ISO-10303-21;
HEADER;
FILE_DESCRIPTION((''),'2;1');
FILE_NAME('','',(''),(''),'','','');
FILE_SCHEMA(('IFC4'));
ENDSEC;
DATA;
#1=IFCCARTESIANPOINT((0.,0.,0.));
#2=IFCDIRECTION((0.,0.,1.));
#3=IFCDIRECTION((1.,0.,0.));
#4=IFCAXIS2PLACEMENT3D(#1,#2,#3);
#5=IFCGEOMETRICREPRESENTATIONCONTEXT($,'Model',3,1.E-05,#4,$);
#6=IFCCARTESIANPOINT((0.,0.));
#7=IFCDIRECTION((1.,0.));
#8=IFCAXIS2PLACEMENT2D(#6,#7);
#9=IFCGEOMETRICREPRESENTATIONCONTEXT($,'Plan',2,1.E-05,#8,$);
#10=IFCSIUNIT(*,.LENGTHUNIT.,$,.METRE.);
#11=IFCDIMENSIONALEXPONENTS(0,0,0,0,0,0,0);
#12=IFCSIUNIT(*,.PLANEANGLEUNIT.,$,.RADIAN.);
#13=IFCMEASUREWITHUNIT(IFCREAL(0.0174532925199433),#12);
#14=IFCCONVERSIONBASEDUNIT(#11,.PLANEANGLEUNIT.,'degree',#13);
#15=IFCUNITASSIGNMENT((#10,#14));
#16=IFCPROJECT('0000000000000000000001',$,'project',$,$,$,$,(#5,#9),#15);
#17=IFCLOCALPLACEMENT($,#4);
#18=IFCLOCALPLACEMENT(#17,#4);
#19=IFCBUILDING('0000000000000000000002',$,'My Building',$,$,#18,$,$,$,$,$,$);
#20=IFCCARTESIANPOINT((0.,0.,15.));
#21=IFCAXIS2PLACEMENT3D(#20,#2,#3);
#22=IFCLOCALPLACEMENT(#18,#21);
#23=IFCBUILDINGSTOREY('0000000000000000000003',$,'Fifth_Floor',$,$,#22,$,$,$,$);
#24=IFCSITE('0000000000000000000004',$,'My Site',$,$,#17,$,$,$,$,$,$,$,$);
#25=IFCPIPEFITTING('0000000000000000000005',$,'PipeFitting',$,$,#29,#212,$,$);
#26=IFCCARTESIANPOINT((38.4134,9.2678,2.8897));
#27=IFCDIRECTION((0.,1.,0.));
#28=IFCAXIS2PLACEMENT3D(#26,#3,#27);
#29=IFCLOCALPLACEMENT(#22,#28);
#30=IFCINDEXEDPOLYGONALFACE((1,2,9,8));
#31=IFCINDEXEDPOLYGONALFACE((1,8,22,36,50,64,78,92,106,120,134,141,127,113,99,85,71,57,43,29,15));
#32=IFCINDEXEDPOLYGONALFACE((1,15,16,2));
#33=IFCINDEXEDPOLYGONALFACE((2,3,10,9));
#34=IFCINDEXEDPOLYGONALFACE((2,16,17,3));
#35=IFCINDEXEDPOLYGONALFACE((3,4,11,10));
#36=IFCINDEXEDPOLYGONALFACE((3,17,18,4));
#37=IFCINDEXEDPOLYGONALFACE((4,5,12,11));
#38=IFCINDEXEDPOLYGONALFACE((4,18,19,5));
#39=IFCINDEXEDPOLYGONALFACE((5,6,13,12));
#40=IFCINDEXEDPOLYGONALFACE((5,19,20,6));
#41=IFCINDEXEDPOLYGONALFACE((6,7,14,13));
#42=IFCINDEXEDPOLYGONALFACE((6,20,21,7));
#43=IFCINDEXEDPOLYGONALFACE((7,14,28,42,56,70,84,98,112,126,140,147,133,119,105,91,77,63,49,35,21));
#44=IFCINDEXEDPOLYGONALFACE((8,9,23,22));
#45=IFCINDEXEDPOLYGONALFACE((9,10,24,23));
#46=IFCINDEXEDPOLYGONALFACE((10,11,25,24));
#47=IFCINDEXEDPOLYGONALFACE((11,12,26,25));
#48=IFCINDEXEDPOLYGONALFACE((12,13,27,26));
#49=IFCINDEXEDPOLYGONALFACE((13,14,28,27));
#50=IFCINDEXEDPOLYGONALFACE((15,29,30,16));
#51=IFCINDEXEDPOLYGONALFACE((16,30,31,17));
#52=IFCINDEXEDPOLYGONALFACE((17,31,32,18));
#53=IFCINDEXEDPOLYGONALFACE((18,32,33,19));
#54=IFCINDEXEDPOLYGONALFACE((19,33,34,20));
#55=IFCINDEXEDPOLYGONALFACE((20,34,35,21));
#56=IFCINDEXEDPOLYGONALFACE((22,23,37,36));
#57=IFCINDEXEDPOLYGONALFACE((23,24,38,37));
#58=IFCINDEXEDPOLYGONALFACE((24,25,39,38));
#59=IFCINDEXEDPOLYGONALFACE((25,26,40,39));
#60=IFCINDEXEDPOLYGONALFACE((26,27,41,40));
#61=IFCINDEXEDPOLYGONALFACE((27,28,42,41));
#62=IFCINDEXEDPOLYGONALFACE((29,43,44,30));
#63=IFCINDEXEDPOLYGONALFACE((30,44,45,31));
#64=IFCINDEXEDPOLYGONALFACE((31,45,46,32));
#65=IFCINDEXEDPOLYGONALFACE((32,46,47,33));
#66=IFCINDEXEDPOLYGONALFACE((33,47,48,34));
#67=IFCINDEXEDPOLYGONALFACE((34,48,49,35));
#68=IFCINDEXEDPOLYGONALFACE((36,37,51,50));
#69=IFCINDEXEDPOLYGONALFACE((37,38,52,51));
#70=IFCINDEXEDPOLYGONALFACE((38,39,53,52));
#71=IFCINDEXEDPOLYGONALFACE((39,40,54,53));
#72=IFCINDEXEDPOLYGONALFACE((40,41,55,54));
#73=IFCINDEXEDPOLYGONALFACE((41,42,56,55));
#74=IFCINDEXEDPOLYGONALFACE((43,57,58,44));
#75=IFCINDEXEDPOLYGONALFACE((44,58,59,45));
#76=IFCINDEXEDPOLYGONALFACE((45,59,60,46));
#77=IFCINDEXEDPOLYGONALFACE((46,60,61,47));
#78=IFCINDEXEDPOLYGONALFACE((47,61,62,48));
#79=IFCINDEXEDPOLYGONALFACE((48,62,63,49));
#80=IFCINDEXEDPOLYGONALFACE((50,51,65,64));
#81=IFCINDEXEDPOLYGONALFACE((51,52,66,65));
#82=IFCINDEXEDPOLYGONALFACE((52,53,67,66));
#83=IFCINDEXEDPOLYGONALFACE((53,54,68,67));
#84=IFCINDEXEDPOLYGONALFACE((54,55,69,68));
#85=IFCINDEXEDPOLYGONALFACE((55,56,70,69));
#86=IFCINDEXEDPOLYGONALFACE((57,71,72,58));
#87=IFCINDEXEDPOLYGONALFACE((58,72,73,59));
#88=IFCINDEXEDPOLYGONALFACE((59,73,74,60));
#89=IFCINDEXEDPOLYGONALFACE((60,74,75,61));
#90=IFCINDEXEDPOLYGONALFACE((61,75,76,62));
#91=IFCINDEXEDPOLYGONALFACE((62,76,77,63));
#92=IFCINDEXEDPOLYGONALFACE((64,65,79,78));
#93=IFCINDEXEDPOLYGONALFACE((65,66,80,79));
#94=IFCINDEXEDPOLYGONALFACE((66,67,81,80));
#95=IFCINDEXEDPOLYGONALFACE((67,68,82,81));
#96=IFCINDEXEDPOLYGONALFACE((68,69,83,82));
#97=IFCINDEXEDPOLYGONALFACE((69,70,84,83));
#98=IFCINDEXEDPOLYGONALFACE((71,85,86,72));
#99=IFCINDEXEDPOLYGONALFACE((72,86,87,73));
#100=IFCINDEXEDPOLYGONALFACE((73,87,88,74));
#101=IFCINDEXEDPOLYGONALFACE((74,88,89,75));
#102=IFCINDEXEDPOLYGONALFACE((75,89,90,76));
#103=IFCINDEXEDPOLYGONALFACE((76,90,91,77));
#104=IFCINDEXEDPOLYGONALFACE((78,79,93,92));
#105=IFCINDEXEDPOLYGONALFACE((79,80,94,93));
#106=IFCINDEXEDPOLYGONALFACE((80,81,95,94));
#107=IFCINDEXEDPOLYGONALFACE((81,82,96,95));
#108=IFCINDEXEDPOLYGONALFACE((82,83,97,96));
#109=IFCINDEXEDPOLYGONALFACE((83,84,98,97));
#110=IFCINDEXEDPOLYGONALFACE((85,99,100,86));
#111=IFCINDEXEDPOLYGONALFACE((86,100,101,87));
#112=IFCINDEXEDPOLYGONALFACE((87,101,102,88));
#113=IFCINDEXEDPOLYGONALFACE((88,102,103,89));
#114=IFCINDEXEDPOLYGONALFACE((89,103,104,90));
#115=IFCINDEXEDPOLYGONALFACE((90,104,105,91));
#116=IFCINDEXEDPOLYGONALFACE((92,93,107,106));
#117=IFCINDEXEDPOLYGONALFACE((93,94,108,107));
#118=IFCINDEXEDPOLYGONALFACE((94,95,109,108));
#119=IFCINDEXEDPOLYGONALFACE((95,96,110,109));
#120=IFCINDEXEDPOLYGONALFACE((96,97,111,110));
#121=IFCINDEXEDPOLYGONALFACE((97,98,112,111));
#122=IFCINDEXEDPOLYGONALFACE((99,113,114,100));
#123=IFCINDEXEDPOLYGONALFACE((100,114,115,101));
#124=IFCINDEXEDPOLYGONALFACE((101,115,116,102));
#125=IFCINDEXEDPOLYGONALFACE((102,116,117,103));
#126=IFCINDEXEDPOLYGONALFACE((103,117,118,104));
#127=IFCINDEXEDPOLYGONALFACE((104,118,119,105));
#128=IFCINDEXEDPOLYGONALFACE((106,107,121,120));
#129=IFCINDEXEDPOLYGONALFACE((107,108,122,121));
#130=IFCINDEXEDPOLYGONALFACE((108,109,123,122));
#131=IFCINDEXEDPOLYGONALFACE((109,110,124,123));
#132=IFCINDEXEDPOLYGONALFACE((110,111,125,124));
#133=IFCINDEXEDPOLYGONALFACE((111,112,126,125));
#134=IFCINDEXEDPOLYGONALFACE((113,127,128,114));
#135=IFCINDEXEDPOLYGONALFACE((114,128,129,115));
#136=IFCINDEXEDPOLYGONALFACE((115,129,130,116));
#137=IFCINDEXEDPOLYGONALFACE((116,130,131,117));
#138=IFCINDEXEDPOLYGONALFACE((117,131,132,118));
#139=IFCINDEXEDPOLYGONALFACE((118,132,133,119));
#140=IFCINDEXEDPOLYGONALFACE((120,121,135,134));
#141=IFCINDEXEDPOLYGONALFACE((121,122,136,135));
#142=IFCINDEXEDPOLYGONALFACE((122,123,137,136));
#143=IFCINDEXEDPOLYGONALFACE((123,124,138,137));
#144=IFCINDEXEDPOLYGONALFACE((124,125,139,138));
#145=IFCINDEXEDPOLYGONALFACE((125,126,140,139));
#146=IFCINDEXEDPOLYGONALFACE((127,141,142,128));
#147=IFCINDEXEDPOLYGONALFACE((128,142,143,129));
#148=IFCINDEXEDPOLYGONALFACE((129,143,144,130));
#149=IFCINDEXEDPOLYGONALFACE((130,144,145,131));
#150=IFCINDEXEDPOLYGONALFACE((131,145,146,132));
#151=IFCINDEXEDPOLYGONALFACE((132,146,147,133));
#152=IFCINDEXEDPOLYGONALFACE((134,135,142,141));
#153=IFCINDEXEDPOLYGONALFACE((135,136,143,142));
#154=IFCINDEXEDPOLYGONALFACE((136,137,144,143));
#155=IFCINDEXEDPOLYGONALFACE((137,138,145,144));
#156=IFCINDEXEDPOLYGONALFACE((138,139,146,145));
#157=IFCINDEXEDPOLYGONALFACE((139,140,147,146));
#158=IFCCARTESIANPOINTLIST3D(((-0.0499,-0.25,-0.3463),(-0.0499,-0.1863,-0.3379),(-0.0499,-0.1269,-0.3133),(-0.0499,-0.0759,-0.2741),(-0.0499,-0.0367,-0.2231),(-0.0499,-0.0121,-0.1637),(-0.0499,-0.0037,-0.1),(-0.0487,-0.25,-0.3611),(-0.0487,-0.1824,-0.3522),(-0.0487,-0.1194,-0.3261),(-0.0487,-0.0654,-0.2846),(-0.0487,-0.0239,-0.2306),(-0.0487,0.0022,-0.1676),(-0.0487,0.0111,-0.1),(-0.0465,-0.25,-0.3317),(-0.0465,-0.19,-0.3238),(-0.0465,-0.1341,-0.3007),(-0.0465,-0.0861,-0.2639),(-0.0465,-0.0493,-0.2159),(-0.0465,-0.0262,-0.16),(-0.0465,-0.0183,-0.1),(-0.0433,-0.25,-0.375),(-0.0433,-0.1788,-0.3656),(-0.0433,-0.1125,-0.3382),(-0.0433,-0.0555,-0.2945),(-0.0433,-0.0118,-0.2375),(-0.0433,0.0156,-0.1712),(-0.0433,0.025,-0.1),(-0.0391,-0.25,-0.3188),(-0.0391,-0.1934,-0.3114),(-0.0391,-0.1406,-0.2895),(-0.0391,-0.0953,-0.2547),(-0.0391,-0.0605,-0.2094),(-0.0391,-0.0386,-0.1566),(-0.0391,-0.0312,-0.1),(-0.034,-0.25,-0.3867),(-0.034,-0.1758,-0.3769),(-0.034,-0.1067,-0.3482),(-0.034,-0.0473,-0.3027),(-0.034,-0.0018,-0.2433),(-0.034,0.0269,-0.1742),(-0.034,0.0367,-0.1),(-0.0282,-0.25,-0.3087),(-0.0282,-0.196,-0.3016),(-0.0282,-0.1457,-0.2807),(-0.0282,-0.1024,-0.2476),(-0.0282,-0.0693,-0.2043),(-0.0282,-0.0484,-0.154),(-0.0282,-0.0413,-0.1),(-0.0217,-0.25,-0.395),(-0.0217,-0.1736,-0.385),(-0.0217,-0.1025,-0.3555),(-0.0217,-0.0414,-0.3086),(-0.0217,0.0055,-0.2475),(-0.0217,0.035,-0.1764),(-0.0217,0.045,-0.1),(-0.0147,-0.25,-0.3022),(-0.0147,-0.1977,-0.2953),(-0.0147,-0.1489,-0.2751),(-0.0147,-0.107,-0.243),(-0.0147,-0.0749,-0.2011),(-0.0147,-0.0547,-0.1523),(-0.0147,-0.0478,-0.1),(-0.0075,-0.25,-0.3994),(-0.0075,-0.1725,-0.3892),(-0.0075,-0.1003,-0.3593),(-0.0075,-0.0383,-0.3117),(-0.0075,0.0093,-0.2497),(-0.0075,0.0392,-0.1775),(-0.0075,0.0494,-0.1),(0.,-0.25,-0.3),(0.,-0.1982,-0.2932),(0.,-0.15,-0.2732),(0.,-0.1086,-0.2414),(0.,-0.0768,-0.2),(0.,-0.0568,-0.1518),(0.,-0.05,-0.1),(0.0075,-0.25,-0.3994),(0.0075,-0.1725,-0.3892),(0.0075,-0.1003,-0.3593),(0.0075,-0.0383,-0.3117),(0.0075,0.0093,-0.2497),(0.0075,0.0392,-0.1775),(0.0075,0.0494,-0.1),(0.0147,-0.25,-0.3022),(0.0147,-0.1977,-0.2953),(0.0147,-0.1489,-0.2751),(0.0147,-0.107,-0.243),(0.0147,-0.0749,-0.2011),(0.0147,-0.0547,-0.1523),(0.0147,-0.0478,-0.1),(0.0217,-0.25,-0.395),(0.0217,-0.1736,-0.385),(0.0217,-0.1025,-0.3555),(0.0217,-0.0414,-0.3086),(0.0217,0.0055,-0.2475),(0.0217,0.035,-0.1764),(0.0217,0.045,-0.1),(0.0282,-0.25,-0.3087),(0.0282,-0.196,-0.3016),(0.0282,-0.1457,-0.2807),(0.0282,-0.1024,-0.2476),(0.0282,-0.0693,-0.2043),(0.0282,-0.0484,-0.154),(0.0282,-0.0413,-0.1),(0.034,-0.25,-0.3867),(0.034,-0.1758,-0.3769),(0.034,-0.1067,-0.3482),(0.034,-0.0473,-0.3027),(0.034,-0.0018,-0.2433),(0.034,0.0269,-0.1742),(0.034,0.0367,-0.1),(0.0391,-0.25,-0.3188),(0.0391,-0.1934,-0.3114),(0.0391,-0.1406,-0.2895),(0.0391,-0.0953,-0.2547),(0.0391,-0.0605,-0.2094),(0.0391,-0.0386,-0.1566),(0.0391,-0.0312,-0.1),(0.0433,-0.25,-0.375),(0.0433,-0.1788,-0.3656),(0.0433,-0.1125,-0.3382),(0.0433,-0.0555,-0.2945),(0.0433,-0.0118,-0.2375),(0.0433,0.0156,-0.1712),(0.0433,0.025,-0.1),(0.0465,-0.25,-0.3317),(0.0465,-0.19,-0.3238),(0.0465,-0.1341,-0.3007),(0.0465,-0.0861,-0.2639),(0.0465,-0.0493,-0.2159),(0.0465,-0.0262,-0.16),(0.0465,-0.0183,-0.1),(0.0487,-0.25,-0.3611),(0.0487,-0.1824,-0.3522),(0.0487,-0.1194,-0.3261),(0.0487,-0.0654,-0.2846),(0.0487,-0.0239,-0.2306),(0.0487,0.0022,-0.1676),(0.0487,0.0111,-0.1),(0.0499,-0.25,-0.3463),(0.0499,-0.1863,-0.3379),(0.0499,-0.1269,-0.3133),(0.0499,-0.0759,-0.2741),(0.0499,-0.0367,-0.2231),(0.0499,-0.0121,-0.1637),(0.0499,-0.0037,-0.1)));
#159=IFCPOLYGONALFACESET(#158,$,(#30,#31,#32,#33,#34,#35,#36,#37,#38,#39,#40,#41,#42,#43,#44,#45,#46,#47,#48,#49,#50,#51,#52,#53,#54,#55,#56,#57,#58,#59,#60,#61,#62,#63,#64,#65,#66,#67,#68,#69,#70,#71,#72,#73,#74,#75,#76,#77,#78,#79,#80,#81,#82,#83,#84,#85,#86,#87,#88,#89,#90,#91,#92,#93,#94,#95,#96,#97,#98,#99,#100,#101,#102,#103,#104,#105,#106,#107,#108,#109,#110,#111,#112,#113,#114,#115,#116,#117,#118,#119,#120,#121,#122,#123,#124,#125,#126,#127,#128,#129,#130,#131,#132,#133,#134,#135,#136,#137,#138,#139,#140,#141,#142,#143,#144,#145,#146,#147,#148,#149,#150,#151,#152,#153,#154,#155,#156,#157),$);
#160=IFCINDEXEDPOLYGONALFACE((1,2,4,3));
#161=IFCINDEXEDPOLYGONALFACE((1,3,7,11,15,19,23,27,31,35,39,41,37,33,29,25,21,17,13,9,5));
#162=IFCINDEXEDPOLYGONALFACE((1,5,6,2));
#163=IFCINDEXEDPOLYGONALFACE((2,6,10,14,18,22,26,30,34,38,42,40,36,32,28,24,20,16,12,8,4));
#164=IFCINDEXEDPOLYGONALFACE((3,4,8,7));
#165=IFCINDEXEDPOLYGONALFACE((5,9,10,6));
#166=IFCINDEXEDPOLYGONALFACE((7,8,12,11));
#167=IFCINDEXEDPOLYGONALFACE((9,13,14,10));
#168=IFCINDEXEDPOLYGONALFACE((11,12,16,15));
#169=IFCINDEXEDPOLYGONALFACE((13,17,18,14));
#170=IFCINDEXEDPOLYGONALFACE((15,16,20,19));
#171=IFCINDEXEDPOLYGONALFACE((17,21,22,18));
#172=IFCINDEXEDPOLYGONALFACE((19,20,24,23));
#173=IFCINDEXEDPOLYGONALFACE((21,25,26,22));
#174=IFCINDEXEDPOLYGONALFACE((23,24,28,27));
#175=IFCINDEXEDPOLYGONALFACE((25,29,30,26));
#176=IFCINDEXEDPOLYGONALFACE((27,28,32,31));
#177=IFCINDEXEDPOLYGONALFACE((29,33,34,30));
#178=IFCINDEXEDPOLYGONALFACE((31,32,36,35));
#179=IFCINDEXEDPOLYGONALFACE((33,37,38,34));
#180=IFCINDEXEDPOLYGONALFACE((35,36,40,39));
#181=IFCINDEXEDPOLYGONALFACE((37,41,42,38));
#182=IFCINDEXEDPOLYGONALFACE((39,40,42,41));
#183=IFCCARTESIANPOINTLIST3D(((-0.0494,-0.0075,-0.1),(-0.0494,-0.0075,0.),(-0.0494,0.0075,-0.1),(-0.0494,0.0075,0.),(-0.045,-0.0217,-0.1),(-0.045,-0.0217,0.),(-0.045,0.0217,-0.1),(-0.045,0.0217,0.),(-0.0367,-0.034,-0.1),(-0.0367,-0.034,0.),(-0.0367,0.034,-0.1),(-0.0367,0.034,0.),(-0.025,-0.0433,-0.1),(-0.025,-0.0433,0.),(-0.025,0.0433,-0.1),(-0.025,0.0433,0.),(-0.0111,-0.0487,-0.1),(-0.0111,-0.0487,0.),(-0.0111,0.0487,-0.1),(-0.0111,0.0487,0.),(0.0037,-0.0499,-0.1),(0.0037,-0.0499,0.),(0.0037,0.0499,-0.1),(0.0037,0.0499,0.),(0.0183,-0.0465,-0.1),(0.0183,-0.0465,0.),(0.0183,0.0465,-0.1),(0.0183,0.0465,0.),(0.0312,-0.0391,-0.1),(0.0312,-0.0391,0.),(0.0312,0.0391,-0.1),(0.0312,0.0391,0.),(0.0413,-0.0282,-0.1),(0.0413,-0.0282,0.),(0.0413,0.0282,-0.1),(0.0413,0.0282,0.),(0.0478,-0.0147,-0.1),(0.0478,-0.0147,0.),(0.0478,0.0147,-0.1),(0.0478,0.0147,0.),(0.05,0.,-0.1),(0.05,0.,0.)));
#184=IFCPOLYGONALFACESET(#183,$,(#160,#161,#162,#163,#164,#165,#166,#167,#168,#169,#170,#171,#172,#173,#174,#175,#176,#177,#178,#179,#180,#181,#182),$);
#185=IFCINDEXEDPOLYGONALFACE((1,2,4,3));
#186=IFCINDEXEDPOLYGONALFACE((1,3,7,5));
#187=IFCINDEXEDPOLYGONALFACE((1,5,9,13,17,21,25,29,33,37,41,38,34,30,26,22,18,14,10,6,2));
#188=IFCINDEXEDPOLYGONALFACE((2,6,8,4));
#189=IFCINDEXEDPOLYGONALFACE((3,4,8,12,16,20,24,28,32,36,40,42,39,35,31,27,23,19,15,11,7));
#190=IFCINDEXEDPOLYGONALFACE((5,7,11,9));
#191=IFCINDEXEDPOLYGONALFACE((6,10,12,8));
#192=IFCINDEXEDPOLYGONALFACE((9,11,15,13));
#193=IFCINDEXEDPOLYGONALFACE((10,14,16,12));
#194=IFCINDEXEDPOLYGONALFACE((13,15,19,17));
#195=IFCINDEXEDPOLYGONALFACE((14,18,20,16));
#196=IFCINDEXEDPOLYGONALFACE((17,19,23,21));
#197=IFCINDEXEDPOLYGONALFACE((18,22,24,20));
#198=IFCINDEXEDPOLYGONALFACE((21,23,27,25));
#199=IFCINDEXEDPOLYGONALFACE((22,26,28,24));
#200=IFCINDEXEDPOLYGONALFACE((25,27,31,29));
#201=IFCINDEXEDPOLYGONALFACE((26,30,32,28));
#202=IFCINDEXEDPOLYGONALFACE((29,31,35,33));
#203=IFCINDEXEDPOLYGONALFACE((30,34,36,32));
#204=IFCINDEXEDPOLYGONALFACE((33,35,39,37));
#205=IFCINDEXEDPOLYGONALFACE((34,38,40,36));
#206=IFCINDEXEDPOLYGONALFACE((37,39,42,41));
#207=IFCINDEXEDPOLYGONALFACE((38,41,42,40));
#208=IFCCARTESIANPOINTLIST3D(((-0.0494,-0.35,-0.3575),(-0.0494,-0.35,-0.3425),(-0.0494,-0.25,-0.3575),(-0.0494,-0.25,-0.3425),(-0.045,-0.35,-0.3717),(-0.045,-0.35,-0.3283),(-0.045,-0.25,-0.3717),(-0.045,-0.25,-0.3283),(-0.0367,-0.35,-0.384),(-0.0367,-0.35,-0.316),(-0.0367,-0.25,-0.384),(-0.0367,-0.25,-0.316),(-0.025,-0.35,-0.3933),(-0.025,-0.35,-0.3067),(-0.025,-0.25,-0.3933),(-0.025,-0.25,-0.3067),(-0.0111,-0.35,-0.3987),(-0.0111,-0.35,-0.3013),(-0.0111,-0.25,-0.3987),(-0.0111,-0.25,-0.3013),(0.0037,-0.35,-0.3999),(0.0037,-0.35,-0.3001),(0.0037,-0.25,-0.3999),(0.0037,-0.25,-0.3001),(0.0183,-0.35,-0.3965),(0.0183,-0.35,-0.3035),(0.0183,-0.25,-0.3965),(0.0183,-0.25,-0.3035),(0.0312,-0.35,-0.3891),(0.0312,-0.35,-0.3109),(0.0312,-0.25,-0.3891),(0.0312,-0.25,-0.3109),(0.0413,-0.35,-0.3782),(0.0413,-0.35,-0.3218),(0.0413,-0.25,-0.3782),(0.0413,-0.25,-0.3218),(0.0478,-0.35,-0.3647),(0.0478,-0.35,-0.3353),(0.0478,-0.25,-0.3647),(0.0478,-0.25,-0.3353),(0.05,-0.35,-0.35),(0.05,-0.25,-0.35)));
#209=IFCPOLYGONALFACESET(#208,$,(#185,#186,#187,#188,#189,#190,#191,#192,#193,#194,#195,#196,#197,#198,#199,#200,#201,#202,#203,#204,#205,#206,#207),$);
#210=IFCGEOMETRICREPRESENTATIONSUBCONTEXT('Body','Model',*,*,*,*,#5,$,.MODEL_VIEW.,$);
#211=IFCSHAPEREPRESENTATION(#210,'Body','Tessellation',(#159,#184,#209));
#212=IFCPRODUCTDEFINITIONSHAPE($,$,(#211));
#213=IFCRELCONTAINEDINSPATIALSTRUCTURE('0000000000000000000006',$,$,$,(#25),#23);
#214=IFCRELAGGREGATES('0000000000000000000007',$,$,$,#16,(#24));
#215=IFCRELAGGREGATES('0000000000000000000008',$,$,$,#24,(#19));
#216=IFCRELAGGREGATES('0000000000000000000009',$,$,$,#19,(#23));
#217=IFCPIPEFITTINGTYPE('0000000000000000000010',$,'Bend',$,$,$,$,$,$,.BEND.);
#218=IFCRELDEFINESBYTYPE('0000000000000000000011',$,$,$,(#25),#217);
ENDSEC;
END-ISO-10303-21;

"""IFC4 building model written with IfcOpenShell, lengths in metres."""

from ifc_helpers import new_model, entity, si_unit, converted_unit, frame, origin_with_axes, origin_2d_with_axis, place, context, subcontext, project, spatial, circle, extrude, source, transform, mapped, type_object, type_shapes, element, save


model = new_model("IFC4")

# Units and contexts
model_context = context("Model", 3, precision=1e-05, world=origin_with_axes())
plan_context = context("Plan", 2, precision=1e-05, world=origin_2d_with_axis())
body_context_1 = subcontext(model_context, "Body", "Model", "MODEL_VIEW")
ifc_project = project(units=[si_unit("LENGTHUNIT", "METRE"), converted_unit("PLANEANGLEUNIT", "degree", entity("IfcReal", 0.0174532925199433), si_unit("PLANEANGLEUNIT", "RADIAN"), dimensions=[0, 0, 0, 0, 0, 0, 0])], contexts=[model_context, plan_context])

# Site, building, storey
site_placement = place(None, origin_with_axes())
site = spatial("IfcSite", under=ifc_project, at=site_placement, Name="My Site")
building_placement = place(site_placement, origin_with_axes())
building = spatial("IfcBuilding", under=site, at=building_placement, Name="My Building")
storey_placement = place(building_placement, frame((0.0, 0.0, 15.0), z_axis=(0.0, 0.0, 1.0), x_axis=(1.0, 0.0, 0.0)))
storey = spatial("IfcBuildingStorey", under=building, at=storey_placement, Name="Fifth_Floor")

# Pipe fitting
pipe_fitting_type = type_object("IfcPipeFittingType", Name="Bend", PredefinedType="BEND")
shared_shape_1 = source(origin_with_axes(), body_context_1, "Body", "SolidModel", [
    entity("IfcSweptDiskSolid", entity("IfcIndexedPolyCurve", entity("IfcCartesianPointList3D", [[0.0, 0.0, -0.1], [0.0, -0.0732, -0.2768], [0.0, -0.25, -0.35]]), [entity("IfcArcIndex", [1, 2, 3])]), 0.05),
    extrude(circle(Radius=0.05), origin_with_axes(), (0.0, 0.0, -1.0), 0.1),
    extrude(circle(Radius=0.05), frame((0.0, -0.25, -0.35), z_axis=(0.0, -1.0, 0.0), x_axis=(1.0, 0.0, 0.0)), (0.0, 0.0, 1.0), 0.1),
])
type_shapes(pipe_fitting_type, [shared_shape_1])
for number, where, z_axis, x_axis, name in (
    (1, (38.4134, 9.2678, 2.8897), (1.0, 0.0, 0.0), (0.0, 1.0, 0.0), "PipeFitting"),
):
    element("IfcPipeFitting", number, at=place(storey_placement, frame(where, z_axis=z_axis, x_axis=x_axis)), inside=storey, type_object=pipe_fitting_type, Name=name, context=body_context_1, shape_type="MappedRepresentation", body=[
        mapped(shared_shape_1, transform((0.0, 0.0, 0.0), x_axis=(1.0, 0.0, 0.0), y_axis=(0.0, 1.0, 0.0), z_axis=(0.0, 0.0, 1.0), scale=1.0)),
    ])

save(model, "model.ifc")
